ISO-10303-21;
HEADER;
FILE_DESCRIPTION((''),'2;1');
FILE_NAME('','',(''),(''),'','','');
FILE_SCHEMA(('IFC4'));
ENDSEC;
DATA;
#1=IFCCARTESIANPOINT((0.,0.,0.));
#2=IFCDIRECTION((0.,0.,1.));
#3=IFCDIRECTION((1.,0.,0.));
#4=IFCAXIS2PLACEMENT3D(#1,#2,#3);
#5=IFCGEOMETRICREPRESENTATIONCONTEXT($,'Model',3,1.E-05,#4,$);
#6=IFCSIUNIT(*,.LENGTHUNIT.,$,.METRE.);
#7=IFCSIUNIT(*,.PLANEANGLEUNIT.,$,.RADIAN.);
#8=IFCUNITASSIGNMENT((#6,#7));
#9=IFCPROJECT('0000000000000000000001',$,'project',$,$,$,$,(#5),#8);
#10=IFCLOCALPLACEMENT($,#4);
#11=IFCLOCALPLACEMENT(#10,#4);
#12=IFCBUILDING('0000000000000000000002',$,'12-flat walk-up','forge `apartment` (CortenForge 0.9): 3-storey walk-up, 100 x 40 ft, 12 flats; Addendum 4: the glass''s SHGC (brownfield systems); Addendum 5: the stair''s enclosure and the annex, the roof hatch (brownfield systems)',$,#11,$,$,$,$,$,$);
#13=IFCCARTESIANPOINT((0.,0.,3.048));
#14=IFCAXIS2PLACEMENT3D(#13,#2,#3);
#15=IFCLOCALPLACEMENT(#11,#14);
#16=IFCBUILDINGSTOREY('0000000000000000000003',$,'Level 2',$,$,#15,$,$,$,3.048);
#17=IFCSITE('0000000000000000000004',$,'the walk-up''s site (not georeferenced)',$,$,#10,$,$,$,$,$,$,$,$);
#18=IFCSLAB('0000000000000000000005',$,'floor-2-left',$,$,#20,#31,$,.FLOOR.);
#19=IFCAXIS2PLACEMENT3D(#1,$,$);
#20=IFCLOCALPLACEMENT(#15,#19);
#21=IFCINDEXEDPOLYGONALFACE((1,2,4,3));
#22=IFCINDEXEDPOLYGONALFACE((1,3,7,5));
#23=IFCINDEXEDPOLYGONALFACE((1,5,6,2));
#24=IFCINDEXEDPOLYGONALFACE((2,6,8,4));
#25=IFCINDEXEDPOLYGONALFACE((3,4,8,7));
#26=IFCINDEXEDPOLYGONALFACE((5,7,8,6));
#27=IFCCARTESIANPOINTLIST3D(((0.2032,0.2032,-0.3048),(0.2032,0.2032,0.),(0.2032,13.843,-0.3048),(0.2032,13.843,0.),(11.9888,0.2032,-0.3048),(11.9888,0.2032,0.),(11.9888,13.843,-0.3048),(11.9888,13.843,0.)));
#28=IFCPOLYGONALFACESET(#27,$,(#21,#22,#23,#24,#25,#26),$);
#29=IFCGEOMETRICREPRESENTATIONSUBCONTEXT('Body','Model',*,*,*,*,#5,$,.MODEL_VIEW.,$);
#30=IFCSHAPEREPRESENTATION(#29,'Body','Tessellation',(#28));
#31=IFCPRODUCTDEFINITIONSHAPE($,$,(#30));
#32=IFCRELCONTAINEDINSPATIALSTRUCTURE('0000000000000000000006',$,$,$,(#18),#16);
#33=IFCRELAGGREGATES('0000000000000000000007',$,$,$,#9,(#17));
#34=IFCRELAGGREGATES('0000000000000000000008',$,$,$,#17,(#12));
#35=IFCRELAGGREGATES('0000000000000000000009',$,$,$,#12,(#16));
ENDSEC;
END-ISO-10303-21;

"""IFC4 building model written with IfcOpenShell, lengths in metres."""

from ifc_helpers import new_model, si_unit, frame, frame_2d, origin, origin_with_axes, place, context, subcontext, project, spatial, rectangle, extrude, element, save


model = new_model("IFC4")

# Units and contexts
model_context = context("Model", 3, precision=1e-05, world=origin_with_axes())
body_context = subcontext(model_context, "Body", "Model", "MODEL_VIEW")
ifc_project = project(units=[si_unit("LENGTHUNIT", "METRE"), si_unit("PLANEANGLEUNIT", "RADIAN")], contexts=[model_context])

# Site, building, storey
site_placement = place(None, origin_with_axes())
site = spatial("IfcSite", under=ifc_project, at=site_placement, Name="the walk-up's site (not georeferenced)")
building_placement = place(site_placement, origin_with_axes())
building = spatial("IfcBuilding", under=site, at=building_placement, Name="12-flat walk-up", Description="forge `apartment` (CortenForge 0.9): 3-storey walk-up, 100 x 40 ft, 12 flats; Addendum 4: the glass's SHGC (brownfield systems); Addendum 5: the stair's enclosure and the annex, the roof hatch (brownfield systems)")
storey_placement = place(building_placement, frame((0.0, 0.0, 3.048), z_axis=(0.0, 0.0, 1.0), x_axis=(1.0, 0.0, 0.0)))
storey = spatial("IfcBuildingStorey", under=building, at=storey_placement, Name="Level 2", Elevation=3.048)

# Slab
slab_placement = place(storey_placement, frame((0.2032, 0.2032, -0.3048), z_axis=(0.0, 0.0, 1.0), x_axis=(1.0, 0.0, 0.0)))
element("IfcSlab", 1, at=slab_placement, inside=storey, Name="floor-2-left", PredefinedType="FLOOR", context=body_context, shape_type="SweptSolid", body=[
    extrude(rectangle(XDim=11.7856, YDim=13.6398, at=frame_2d((5.8928, 6.8199))), origin(), (0.0, 0.0, 1.0), 0.3048),
])

save(model, "model.ifc")
